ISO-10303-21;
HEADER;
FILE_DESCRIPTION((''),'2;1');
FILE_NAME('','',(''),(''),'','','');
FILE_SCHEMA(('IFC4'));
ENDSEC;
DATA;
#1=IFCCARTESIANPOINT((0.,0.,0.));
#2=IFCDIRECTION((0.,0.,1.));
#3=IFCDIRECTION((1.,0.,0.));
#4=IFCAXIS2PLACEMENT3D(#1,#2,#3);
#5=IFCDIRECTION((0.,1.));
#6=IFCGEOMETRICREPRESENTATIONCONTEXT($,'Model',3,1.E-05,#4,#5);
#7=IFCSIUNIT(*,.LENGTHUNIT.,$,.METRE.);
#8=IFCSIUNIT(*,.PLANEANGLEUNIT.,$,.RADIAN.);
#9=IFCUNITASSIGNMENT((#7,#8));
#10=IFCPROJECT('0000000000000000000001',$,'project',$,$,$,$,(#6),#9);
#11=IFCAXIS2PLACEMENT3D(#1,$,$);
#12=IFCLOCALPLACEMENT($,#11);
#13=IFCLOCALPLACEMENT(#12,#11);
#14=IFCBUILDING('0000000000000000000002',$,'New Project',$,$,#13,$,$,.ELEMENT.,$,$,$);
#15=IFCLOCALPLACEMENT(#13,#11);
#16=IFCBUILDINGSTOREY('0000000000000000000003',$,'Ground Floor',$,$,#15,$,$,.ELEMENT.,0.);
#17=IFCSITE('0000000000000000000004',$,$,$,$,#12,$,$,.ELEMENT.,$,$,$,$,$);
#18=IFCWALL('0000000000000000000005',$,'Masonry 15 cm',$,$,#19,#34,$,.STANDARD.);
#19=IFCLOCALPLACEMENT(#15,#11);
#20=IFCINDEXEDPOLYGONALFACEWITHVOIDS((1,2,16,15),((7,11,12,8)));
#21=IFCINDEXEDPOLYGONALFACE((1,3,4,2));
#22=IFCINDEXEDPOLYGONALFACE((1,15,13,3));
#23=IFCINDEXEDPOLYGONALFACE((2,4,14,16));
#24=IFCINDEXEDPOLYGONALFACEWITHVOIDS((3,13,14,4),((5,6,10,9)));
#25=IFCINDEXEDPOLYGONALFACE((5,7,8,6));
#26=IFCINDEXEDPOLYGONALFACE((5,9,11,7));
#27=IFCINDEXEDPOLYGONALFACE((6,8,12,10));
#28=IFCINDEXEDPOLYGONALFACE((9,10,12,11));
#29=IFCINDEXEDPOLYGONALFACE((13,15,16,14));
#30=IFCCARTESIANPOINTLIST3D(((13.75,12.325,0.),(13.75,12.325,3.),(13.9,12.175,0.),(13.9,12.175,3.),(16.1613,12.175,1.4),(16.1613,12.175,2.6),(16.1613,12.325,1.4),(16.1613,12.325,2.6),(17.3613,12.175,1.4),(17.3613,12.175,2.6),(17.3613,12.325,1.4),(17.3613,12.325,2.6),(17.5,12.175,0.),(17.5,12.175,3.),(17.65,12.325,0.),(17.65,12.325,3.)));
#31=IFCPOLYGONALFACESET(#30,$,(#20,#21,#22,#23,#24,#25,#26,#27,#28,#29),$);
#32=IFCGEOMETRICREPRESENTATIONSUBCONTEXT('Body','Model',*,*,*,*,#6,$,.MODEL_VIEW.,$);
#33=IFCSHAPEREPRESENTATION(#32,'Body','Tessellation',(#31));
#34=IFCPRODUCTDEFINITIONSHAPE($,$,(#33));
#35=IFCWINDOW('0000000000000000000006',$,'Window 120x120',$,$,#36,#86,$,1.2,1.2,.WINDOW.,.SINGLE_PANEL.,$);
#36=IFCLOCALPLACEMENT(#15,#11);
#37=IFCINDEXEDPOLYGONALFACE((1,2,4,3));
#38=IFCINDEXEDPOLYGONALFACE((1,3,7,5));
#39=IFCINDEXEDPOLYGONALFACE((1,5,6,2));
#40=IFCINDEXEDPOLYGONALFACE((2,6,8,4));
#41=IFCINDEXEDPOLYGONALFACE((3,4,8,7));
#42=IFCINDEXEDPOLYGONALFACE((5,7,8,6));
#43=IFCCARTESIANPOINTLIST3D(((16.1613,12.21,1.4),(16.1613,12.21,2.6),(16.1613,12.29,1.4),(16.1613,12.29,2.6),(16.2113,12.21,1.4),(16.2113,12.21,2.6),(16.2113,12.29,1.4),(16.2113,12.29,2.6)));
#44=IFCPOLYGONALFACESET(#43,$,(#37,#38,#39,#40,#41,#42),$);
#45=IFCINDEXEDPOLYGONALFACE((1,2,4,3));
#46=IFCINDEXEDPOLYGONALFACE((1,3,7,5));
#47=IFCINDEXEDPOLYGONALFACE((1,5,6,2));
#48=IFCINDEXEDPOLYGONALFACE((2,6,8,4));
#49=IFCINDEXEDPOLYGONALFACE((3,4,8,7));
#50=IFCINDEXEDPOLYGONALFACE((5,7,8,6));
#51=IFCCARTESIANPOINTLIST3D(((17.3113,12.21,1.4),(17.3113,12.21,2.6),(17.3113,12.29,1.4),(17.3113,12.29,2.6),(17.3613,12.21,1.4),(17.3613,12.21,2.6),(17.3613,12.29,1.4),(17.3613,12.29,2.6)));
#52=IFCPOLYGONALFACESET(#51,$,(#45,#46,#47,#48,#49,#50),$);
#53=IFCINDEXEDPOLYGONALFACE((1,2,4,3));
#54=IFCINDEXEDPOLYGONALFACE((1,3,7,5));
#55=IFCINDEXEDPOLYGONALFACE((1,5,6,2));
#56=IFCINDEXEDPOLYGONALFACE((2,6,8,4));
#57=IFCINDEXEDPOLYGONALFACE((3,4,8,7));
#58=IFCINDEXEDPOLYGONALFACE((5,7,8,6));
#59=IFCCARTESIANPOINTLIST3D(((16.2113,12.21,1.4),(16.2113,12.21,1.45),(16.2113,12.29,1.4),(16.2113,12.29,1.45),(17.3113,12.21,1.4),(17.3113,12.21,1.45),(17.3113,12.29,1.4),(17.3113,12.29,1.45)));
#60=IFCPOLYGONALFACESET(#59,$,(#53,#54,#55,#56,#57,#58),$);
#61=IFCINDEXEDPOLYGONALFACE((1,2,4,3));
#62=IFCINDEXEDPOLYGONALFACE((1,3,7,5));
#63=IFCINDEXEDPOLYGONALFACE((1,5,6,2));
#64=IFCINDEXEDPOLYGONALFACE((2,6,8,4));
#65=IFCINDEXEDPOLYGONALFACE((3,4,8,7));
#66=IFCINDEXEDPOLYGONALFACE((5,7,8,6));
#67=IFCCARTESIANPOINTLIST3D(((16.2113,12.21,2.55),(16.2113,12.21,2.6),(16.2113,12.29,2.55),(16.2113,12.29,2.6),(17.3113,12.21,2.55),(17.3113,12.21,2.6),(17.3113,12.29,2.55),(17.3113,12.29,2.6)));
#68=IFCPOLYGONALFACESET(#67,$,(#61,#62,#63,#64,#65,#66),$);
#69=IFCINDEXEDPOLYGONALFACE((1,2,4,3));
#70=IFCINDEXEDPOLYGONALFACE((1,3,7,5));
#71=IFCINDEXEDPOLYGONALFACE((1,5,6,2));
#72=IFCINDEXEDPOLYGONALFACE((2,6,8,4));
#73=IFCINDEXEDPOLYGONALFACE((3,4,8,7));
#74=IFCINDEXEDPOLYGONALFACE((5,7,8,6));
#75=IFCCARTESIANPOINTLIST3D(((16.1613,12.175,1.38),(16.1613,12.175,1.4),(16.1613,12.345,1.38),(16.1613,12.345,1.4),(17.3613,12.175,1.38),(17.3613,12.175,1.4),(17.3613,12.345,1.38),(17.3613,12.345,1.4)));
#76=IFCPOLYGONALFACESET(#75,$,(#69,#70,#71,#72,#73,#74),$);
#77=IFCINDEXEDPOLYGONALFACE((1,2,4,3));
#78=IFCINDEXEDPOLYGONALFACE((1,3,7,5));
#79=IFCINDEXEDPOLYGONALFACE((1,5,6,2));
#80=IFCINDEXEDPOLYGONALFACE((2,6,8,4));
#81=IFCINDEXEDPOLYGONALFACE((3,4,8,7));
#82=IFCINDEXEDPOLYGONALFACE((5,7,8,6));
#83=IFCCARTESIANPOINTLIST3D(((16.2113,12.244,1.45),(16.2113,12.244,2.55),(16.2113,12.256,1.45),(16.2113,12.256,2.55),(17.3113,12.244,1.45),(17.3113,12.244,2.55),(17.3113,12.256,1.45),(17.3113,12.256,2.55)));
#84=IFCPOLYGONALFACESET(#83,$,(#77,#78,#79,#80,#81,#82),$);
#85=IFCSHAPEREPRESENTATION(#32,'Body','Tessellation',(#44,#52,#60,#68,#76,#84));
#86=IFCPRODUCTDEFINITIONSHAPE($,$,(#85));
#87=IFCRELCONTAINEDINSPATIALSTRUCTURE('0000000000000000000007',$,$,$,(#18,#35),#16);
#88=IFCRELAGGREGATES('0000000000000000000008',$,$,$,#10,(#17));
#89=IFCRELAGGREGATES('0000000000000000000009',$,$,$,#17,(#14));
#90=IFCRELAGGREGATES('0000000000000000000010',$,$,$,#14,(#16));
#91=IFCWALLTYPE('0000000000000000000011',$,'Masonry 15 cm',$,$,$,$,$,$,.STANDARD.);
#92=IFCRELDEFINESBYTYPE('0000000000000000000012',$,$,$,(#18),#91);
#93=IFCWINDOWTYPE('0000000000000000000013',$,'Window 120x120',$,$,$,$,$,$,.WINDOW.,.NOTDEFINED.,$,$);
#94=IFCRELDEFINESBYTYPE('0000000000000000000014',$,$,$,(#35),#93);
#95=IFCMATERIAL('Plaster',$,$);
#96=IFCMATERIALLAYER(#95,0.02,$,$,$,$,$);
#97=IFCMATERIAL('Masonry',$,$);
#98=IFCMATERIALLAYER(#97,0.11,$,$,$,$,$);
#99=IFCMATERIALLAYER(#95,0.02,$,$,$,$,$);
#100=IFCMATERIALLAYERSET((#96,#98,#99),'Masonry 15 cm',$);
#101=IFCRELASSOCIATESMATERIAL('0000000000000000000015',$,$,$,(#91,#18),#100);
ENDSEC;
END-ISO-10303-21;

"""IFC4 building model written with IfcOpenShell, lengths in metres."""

from ifc_helpers import new_model, si_unit, direction, frame, frame_2d, origin, origin_with_axes, place, context, subcontext, project, spatial, polyline, rectangle, outline, extrude, material, layer, layer_set, layer_usage, type_object, element, fill, save


model = new_model("IFC4")

# Units and contexts
model_context = context("Model", 3, precision=1e-05, world=origin_with_axes(), true_north=direction((0.0, 1.0)))
body_context = subcontext(model_context, "Body", "Model", "MODEL_VIEW")
ifc_project = project(units=[si_unit("LENGTHUNIT", "METRE"), si_unit("PLANEANGLEUNIT", "RADIAN")], contexts=[model_context])

# Site, building, storey
site_placement = place(None, origin())
site = spatial("IfcSite", under=ifc_project, at=site_placement, CompositionType="ELEMENT")
building_placement = place(site_placement, origin())
building = spatial("IfcBuilding", under=site, at=building_placement, Name="New Project", CompositionType="ELEMENT")
storey_placement = place(building_placement, origin())
storey = spatial("IfcBuildingStorey", under=building, at=storey_placement, Name="Ground Floor", CompositionType="ELEMENT", Elevation=0.0)

# Shared definitions
ifc_material_1 = material(Name="Plaster")
ifc_layer_1 = layer(ifc_material_1, 0.02)
ifc_material_2 = material(Name="Masonry")
ifc_layer_2 = layer(ifc_material_2, 0.11)
ifc_layer_3 = layer(ifc_material_1, 0.02)
ifc_layer_set_1 = layer_set([ifc_layer_1, ifc_layer_2, ifc_layer_3], Name="Masonry 15 cm")
ifc_layer_usage_1 = layer_usage(ifc_layer_set_1, "AXIS2", "NEGATIVE", 0.075)
wall_type_1 = type_object("IfcWallType", Name="Masonry 15 cm", PredefinedType="STANDARD", material=ifc_layer_set_1)

# Shared definitions
window_type = type_object("IfcWindowType", Name="Window 120x120", PartitioningType="NOTDEFINED", PredefinedType="WINDOW")

# Wall, opening, window
wall_1_placement = place(storey_placement, frame((13.825, 12.25, 0.0)))
wall_1 = element("IfcWall", 1, at=wall_1_placement, inside=storey, type_object=wall_type_1, material=ifc_layer_usage_1, Name="Masonry 15 cm", PredefinedType="STANDARD", context=body_context, shape_type="SweptSolid", body=[
    extrude(outline(polyline([(0.075, -0.075), (3.675, -0.075), (3.825, 0.075), (-0.075, 0.075), (0.075, -0.075)])), origin(), (0.0, 0.0, 1.0), 3.0),
])
opening_1_placement = place(wall_1_placement, frame((2.3363, 0.0, 1.4)))
opening_1 = element("IfcOpeningElement", 2, at=opening_1_placement, cuts=wall_1, PredefinedType="OPENING", context=body_context, shape_type="SweptSolid", body=[
    extrude(rectangle(XDim=1.2, YDim=0.25, at=frame_2d((0.6, 0.0))), origin(), (0.0, 0.0, 1.0), 1.2),
])
window_1_placement = place(opening_1_placement, origin())
window_1 = element("IfcWindow", 3, at=window_1_placement, inside=storey, type_object=window_type, Name="Window 120x120", OverallHeight=1.2, OverallWidth=1.2, PartitioningType="SINGLE_PANEL", PredefinedType="WINDOW", context=body_context, shape_type="SweptSolid", body=[
    extrude(outline(polyline([(0.0, -0.04), (0.05, -0.04), (0.05, 0.04), (0.0, 0.04), (0.0, -0.04)])), origin(), (0.0, 0.0, 1.0), 1.2),
    extrude(outline(polyline([(1.15, -0.04), (1.2, -0.04), (1.2, 0.04), (1.15, 0.04), (1.15, -0.04)])), origin(), (0.0, 0.0, 1.0), 1.2),
    extrude(outline(polyline([(0.05, -0.04), (1.15, -0.04), (1.15, 0.04), (0.05, 0.04), (0.05, -0.04)])), origin(), (0.0, 0.0, 1.0), 0.05),
    extrude(outline(polyline([(0.05, -0.04), (1.15, -0.04), (1.15, 0.04), (0.05, 0.04), (0.05, -0.04)])), frame((0.0, 0.0, 1.15)), (0.0, 0.0, 1.0), 0.05),
    extrude(outline(polyline([(0.0, -0.075), (1.2, -0.075), (1.2, 0.095), (0.0, 0.095), (0.0, -0.075)])), frame((0.0, 0.0, -0.02)), (0.0, 0.0, 1.0), 0.02),
    extrude(outline(polyline([(0.05, -0.006), (1.15, -0.006), (1.15, 0.006), (0.05, 0.006), (0.05, -0.006)])), frame((0.0, 0.0, 0.05)), (0.0, 0.0, 1.0), 1.1),
])
fill(opening_1, window_1)

save(model, "model.ifc")
